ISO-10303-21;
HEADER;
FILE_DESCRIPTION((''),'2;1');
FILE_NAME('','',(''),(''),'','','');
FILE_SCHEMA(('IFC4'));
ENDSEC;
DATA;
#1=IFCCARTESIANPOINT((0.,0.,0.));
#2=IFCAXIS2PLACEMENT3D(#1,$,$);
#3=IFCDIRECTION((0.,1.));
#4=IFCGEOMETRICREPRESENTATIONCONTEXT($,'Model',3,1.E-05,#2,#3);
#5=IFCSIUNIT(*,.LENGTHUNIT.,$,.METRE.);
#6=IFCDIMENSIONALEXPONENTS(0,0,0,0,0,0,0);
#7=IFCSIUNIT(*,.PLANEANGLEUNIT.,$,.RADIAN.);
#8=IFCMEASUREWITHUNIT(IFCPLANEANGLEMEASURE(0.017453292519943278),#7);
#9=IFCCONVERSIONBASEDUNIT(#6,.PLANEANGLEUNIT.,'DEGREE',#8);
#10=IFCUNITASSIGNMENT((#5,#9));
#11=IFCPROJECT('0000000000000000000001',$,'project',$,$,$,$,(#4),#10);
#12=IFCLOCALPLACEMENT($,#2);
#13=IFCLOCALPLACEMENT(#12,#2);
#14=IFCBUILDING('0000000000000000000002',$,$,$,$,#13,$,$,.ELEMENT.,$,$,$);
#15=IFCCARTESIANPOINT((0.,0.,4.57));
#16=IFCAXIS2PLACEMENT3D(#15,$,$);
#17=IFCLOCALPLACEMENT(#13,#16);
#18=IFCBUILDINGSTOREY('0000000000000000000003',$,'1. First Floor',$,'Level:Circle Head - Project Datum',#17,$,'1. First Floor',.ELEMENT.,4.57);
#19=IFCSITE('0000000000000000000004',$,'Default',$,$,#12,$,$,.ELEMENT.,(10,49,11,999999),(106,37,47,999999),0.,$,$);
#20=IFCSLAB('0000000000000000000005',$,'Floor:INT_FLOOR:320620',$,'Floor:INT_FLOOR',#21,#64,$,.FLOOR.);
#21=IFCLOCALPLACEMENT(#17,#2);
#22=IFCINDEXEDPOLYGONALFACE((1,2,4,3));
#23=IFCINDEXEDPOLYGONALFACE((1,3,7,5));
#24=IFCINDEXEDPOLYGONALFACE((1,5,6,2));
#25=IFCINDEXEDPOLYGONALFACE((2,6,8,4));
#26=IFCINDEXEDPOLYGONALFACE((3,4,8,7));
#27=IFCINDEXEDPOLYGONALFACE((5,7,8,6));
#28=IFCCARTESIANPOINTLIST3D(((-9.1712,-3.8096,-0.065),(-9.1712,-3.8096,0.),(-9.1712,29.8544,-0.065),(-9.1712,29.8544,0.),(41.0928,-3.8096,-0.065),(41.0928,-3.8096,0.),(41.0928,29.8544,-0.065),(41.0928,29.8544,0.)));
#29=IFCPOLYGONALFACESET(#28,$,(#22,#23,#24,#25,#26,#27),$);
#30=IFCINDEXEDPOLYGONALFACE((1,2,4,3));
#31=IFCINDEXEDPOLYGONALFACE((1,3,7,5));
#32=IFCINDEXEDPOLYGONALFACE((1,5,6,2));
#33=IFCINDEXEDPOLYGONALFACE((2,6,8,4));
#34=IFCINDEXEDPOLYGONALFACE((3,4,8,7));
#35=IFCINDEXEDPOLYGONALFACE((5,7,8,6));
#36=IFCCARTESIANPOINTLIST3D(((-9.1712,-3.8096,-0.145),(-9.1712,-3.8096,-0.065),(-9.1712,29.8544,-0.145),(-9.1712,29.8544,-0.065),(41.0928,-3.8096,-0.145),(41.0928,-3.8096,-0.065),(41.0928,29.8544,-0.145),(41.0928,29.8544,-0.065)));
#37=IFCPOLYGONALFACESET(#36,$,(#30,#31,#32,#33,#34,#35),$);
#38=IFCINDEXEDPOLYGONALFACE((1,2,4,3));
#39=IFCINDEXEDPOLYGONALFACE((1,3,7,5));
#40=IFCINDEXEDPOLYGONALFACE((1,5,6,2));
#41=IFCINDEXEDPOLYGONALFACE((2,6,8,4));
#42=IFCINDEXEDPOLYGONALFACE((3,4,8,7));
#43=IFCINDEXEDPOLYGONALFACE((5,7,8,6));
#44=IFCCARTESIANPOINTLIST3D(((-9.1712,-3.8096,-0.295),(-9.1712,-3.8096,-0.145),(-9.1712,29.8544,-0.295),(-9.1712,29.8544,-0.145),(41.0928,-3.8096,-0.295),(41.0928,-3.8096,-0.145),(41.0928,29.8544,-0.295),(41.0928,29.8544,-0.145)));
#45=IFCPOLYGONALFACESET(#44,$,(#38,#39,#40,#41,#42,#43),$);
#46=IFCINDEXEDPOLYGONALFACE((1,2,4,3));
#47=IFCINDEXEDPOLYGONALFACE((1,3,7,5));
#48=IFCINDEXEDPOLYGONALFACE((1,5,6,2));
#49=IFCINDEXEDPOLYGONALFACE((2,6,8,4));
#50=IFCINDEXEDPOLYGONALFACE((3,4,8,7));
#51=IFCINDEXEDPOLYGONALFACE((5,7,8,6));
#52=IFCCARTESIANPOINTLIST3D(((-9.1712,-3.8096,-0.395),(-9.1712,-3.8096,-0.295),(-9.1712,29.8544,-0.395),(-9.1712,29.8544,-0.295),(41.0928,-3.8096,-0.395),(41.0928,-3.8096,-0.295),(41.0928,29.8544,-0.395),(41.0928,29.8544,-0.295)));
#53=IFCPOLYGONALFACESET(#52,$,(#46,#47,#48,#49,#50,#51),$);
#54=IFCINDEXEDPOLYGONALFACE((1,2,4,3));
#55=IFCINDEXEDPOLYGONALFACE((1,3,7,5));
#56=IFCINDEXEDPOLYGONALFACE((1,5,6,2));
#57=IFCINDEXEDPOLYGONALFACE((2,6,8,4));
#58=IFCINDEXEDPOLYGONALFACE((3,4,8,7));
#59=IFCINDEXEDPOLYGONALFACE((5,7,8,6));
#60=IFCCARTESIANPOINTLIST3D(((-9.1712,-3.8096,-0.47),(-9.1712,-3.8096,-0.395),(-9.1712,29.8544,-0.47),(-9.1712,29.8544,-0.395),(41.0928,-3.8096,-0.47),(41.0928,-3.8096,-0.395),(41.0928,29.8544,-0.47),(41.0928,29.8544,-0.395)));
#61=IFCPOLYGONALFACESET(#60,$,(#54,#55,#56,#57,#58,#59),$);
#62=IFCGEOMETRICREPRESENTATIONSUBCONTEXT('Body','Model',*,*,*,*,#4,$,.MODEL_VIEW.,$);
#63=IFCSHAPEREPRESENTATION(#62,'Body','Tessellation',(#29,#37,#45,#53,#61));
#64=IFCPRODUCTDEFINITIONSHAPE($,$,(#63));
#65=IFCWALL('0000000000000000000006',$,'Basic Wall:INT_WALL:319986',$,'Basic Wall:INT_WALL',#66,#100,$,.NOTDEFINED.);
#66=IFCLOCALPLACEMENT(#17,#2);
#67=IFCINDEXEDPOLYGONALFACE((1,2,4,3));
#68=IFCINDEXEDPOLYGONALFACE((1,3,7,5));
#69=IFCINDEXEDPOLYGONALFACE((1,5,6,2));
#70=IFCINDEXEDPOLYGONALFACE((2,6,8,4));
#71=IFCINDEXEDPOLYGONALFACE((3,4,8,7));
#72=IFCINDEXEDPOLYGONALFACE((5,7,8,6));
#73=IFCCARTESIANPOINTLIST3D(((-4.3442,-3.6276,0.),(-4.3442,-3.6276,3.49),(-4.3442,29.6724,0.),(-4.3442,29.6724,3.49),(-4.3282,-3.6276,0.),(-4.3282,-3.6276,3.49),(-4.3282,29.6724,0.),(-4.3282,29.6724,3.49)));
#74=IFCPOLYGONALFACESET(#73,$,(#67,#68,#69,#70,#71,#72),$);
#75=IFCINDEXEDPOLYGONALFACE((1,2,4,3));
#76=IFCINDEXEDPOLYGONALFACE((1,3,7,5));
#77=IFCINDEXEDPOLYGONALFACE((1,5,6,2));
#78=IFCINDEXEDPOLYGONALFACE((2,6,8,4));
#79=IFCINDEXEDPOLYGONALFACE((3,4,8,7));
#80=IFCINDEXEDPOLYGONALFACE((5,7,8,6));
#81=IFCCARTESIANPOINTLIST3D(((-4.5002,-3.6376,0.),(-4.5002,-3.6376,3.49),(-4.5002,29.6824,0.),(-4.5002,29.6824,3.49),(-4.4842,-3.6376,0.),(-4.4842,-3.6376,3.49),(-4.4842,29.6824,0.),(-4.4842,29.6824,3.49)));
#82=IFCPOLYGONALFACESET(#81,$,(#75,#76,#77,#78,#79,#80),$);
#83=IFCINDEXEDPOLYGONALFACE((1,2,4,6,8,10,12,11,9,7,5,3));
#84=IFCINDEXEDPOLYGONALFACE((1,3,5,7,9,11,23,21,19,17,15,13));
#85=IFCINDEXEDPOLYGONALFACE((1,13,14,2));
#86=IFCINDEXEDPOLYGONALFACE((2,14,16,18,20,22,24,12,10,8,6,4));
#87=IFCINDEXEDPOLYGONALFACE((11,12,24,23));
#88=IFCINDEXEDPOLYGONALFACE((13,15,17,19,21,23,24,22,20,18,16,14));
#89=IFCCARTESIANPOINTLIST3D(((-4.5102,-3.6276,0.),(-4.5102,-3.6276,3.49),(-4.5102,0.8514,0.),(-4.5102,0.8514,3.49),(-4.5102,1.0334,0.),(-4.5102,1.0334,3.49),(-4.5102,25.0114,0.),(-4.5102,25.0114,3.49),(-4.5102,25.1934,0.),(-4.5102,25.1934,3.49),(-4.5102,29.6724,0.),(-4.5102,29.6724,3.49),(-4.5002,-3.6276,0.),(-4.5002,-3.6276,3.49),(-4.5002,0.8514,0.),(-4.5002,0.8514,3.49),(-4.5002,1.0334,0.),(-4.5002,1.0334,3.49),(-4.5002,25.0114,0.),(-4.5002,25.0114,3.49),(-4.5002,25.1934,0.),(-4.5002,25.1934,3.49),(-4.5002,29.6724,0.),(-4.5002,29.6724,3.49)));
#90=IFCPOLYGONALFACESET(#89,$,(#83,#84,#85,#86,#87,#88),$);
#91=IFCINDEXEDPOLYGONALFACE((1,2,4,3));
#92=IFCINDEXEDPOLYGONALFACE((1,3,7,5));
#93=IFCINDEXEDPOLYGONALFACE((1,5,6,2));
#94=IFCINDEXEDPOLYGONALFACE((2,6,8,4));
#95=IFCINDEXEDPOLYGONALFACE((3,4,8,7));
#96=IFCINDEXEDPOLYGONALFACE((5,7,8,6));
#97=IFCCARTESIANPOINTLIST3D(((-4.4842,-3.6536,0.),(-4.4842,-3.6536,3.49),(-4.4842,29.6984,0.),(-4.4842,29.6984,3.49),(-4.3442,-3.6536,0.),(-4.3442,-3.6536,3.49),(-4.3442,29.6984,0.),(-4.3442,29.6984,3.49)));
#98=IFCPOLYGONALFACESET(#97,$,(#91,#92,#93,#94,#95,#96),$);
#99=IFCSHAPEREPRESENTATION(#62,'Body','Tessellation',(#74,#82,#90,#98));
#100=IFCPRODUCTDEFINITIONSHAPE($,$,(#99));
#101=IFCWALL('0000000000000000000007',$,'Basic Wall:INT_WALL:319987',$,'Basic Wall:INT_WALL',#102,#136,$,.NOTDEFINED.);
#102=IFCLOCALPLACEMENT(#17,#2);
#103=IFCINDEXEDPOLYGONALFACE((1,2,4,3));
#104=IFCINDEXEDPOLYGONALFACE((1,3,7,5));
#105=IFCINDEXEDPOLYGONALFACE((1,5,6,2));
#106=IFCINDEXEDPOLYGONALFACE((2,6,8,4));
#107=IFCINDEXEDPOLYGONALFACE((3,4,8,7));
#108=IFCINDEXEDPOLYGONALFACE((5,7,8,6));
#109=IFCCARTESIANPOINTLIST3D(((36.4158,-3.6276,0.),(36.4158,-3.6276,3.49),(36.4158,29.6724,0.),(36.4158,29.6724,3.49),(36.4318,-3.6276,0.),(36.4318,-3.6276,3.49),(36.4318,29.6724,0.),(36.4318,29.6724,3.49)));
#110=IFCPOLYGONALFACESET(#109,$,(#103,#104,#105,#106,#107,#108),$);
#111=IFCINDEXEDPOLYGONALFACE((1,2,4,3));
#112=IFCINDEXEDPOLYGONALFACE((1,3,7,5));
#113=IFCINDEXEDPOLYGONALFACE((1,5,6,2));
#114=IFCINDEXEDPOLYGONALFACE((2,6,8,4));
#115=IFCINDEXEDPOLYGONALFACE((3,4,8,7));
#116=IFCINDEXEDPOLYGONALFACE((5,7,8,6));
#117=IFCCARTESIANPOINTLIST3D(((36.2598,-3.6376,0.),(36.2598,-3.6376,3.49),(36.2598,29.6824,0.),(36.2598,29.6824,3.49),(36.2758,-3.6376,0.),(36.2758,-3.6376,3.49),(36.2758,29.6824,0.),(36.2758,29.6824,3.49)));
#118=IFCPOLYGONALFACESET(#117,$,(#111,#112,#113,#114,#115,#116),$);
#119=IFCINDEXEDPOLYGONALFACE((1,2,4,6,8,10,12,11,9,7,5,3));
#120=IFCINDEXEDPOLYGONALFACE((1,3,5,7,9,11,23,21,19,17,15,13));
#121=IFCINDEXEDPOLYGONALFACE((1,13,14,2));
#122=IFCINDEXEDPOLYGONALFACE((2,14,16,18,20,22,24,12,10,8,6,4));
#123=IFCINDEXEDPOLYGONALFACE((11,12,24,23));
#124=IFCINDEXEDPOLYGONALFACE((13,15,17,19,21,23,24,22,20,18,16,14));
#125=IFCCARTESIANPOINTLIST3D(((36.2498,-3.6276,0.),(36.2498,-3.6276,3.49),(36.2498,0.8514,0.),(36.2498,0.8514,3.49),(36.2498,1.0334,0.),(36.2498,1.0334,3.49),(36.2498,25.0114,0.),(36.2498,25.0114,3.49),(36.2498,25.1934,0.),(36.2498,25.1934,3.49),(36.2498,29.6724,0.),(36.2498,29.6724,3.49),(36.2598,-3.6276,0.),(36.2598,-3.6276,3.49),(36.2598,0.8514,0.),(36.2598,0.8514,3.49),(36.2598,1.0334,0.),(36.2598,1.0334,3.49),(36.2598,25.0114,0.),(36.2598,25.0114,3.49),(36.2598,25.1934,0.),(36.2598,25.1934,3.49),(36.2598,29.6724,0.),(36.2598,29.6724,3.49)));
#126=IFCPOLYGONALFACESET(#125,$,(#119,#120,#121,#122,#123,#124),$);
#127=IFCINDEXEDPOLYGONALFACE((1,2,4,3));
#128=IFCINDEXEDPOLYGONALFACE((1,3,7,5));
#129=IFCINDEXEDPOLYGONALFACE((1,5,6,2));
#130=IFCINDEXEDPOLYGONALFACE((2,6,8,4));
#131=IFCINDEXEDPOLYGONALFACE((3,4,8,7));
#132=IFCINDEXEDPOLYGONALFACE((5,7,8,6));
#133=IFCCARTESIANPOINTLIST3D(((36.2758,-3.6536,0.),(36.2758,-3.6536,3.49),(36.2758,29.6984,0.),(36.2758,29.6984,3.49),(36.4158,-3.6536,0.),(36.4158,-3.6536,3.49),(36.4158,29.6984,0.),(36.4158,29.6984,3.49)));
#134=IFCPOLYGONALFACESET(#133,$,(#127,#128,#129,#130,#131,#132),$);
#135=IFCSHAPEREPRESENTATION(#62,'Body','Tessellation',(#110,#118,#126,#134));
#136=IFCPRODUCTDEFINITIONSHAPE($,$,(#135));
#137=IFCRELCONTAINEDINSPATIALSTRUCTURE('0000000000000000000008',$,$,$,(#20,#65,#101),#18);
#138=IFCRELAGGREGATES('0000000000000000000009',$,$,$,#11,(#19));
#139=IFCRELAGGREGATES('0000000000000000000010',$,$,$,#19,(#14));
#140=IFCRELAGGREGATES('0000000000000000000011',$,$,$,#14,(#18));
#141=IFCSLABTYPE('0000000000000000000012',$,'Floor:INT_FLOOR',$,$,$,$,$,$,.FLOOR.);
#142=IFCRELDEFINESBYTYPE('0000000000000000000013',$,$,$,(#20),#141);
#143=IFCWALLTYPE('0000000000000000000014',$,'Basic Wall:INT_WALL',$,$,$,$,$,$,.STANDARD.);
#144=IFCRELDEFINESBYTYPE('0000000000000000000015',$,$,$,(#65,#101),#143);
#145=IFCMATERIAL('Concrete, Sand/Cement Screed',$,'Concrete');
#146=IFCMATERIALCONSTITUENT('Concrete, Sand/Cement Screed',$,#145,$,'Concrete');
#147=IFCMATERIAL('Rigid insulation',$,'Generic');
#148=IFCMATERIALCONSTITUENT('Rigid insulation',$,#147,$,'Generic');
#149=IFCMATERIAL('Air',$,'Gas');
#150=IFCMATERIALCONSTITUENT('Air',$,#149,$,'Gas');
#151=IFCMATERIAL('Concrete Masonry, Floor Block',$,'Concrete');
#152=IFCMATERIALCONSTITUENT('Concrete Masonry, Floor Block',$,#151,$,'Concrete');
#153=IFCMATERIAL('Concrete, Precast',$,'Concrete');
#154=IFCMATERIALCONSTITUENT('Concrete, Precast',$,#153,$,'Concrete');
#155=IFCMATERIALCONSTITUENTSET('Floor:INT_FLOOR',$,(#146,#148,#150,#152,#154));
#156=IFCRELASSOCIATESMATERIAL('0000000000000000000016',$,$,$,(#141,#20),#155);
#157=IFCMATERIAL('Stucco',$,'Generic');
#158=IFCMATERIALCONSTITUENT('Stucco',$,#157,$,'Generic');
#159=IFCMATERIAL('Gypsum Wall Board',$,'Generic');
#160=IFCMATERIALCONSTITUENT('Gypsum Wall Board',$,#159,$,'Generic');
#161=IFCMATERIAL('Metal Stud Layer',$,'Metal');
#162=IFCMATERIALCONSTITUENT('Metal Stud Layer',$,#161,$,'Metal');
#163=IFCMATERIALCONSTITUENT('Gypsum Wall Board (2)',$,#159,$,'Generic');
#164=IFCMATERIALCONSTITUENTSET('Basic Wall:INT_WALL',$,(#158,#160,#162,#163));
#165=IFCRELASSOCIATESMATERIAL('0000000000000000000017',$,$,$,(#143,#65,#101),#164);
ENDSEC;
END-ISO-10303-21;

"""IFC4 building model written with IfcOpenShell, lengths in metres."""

from ifc_helpers import new_model, entity, si_unit, converted_unit, direction, frame, origin, place, context, subcontext, project, spatial, indexed_curve, outline, extrude, material, constituent, constituent_set, type_object, element, save


model = new_model("IFC4")

# Units and contexts
model_context = context("Model", 3, precision=1e-05, world=origin(), true_north=direction((0.0, 1.0)))
body_context = subcontext(model_context, "Body", "Model", "MODEL_VIEW")
ifc_project = project(units=[si_unit("LENGTHUNIT", "METRE"), converted_unit("PLANEANGLEUNIT", "DEGREE", entity("IfcPlaneAngleMeasure", 0.017453292519943278), si_unit("PLANEANGLEUNIT", "RADIAN"), dimensions=[0, 0, 0, 0, 0, 0, 0])], contexts=[model_context])

# Site, building, storey
site_placement = place(None, origin())
site = spatial("IfcSite", under=ifc_project, at=site_placement, Name="Default", CompositionType="ELEMENT", RefLatitude=(10, 49, 11, 999999), RefLongitude=(106, 37, 47, 999999), RefElevation=0.0)
building_placement = place(site_placement, origin())
building = spatial("IfcBuilding", under=site, at=building_placement, CompositionType="ELEMENT")
storey_placement = place(building_placement, frame((0.0, 0.0, 4.57)))
storey = spatial("IfcBuildingStorey", under=building, at=storey_placement, Name="1. First Floor", ObjectType="Level:Circle Head - Project Datum", LongName="1. First Floor", CompositionType="ELEMENT", Elevation=4.57)

# Slab
ifc_material_1 = material(Name="Concrete, Sand/Cement Screed", Category="Concrete")
ifc_constituent_1 = constituent(ifc_material_1, Name="Concrete, Sand/Cement Screed", Category="Concrete")
ifc_material_2 = material(Name="Rigid insulation", Category="Generic")
ifc_constituent_2 = constituent(ifc_material_2, Name="Rigid insulation", Category="Generic")
ifc_material_3 = material(Name="Air", Category="Gas")
ifc_constituent_3 = constituent(ifc_material_3, Name="Air", Category="Gas")
ifc_material_4 = material(Name="Concrete Masonry, Floor Block", Category="Concrete")
ifc_constituent_4 = constituent(ifc_material_4, Name="Concrete Masonry, Floor Block", Category="Concrete")
ifc_material_5 = material(Name="Concrete, Precast", Category="Concrete")
ifc_constituent_5 = constituent(ifc_material_5, Name="Concrete, Precast", Category="Concrete")
ifc_constituent_set_1 = constituent_set(constituents=[ifc_constituent_1, ifc_constituent_2, ifc_constituent_3, ifc_constituent_4, ifc_constituent_5], Name="Floor:INT_FLOOR")
slab_type = type_object("IfcSlabType", Name="Floor:INT_FLOOR", PredefinedType="FLOOR", material=ifc_constituent_set_1)
slab_placement = place(storey_placement, origin())
element("IfcSlab", 1, at=slab_placement, inside=storey, type_object=slab_type, material=ifc_constituent_set_1, Name="Floor:INT_FLOOR:320620", ObjectType="Floor:INT_FLOOR", PredefinedType="FLOOR", context=body_context, shape_type="SweptSolid", body=[
    extrude(outline(indexed_curve([(-25.132, -16.832), (25.132, -16.832), (25.132, 16.832), (-25.132, 16.832), (-25.132, -16.832)], self_intersect=False)), frame((15.9608, 13.0224, -0.065), z_axis=(0.0, 0.0, 1.0), x_axis=(-1.0, 0.0, 0.0)), (0.0, 0.0, 1.0), 0.065),
    extrude(outline(indexed_curve([(-25.132, -16.832), (25.132, -16.832), (25.132, 16.832), (-25.132, 16.832), (-25.132, -16.832)], self_intersect=False)), frame((15.9608, 13.0224, -0.145), z_axis=(0.0, 0.0, 1.0), x_axis=(-1.0, 0.0, 0.0)), (0.0, 0.0, 1.0), 0.08),
    extrude(outline(indexed_curve([(-25.132, -16.832), (25.132, -16.832), (25.132, 16.832), (-25.132, 16.832), (-25.132, -16.832)], self_intersect=False)), frame((15.9608, 13.0224, -0.295), z_axis=(0.0, 0.0, 1.0), x_axis=(-1.0, 0.0, 0.0)), (0.0, 0.0, 1.0), 0.15),
    extrude(outline(indexed_curve([(-25.132, -16.832), (25.132, -16.832), (25.132, 16.832), (-25.132, 16.832), (-25.132, -16.832)], self_intersect=False)), frame((15.9608, 13.0224, -0.395), z_axis=(0.0, 0.0, 1.0), x_axis=(-1.0, 0.0, 0.0)), (0.0, 0.0, 1.0), 0.1),
    extrude(outline(indexed_curve([(-25.132, -16.832), (25.132, -16.832), (25.132, 16.832), (-25.132, 16.832), (-25.132, -16.832)], self_intersect=False)), frame((15.9608, 13.0224, -0.47), z_axis=(0.0, 0.0, 1.0), x_axis=(-1.0, 0.0, 0.0)), (0.0, 0.0, 1.0), 0.075),
])

# Walls
ifc_material_6 = material(Name="Stucco", Category="Generic")
ifc_constituent_6 = constituent(ifc_material_6, Name="Stucco", Category="Generic")
ifc_material_7 = material(Name="Gypsum Wall Board", Category="Generic")
ifc_constituent_7 = constituent(ifc_material_7, Name="Gypsum Wall Board", Category="Generic")
ifc_material_8 = material(Name="Metal Stud Layer", Category="Metal")
ifc_constituent_8 = constituent(ifc_material_8, Name="Metal Stud Layer", Category="Metal")
ifc_constituent_9 = constituent(ifc_material_7, Name="Gypsum Wall Board (2)", Category="Generic")
ifc_constituent_set_2 = constituent_set(constituents=[ifc_constituent_6, ifc_constituent_7, ifc_constituent_8, ifc_constituent_9], Name="Basic Wall:INT_WALL")
wall_type_1 = type_object("IfcWallType", Name="Basic Wall:INT_WALL", PredefinedType="STANDARD", material=ifc_constituent_set_2)
wall_1_placement = place(storey_placement, frame((-4.4192, -3.6276, 0.0), z_axis=(0.0, 0.0, 1.0), x_axis=(0.0, 1.0, 0.0)))
element("IfcWall", 2, at=wall_1_placement, inside=storey, type_object=wall_type_1, material=ifc_constituent_set_2, Name="Basic Wall:INT_WALL:319986", ObjectType="Basic Wall:INT_WALL", PredefinedType="NOTDEFINED", context=body_context, shape_type="SweptSolid", body=[
    extrude(outline(indexed_curve([(-1.745, -16.65), (1.745, -16.65), (1.745, 16.65), (-1.745, 16.65), (-1.745, -16.65)], self_intersect=False)), frame((16.65, -0.075, 1.745), z_axis=(0.0, -1.0, 0.0), x_axis=(0.0, 0.0, 1.0)), (0.0, 0.0, 1.0), 0.016),
    extrude(outline(indexed_curve([(-1.745, -16.66), (1.745, -16.66), (1.745, 16.66), (-1.745, 16.66), (-1.745, -16.66)], self_intersect=False)), frame((16.65, 0.081, 1.745), z_axis=(0.0, -1.0, 0.0), x_axis=(0.0, 0.0, 1.0)), (0.0, 0.0, 1.0), 0.016),
    extrude(outline(indexed_curve([(-16.65, -1.745), (-12.171, -1.745), (-11.989, -1.745), (11.989, -1.745), (12.171, -1.745), (16.65, -1.745), (16.65, 1.745), (12.171, 1.745), (11.989, 1.745), (-11.989, 1.745), (-12.171, 1.745), (-16.65, 1.745), (-16.65, -1.745)], self_intersect=False)), frame((16.65, 0.091, 1.745), z_axis=(0.0, -1.0, 0.0), x_axis=(1.0, 0.0, 0.0)), (0.0, 0.0, 1.0), 0.01),
    extrude(outline(indexed_curve([(-1.745, -16.676), (1.745, -16.676), (1.745, 16.676), (-1.745, 16.676), (-1.745, -16.676)], self_intersect=False)), frame((16.65, 0.065, 1.745), z_axis=(0.0, -1.0, 0.0), x_axis=(0.0, 0.0, 1.0)), (0.0, 0.0, 1.0), 0.14),
])
wall_2_placement = place(storey_placement, frame((36.3408, -3.6276, 0.0), z_axis=(0.0, 0.0, 1.0), x_axis=(0.0, 1.0, 0.0)))
element("IfcWall", 3, at=wall_2_placement, inside=storey, type_object=wall_type_1, material=ifc_constituent_set_2, Name="Basic Wall:INT_WALL:319987", ObjectType="Basic Wall:INT_WALL", PredefinedType="NOTDEFINED", context=body_context, shape_type="SweptSolid", body=[
    extrude(outline(indexed_curve([(-1.745, -16.65), (1.745, -16.65), (1.745, 16.65), (-1.745, 16.65), (-1.745, -16.65)], self_intersect=False)), frame((16.65, -0.075, 1.745), z_axis=(0.0, -1.0, 0.0), x_axis=(0.0, 0.0, 1.0)), (0.0, 0.0, 1.0), 0.016),
    extrude(outline(indexed_curve([(-1.745, -16.66), (1.745, -16.66), (1.745, 16.66), (-1.745, 16.66), (-1.745, -16.66)], self_intersect=False)), frame((16.65, 0.081, 1.745), z_axis=(0.0, -1.0, 0.0), x_axis=(0.0, 0.0, 1.0)), (0.0, 0.0, 1.0), 0.016),
    extrude(outline(indexed_curve([(-16.65, -1.745), (-12.171, -1.745), (-11.989, -1.745), (11.989, -1.745), (12.171, -1.745), (16.65, -1.745), (16.65, 1.745), (12.171, 1.745), (11.989, 1.745), (-11.989, 1.745), (-12.171, 1.745), (-16.65, 1.745), (-16.65, -1.745)], self_intersect=False)), frame((16.65, 0.091, 1.745), z_axis=(0.0, -1.0, 0.0), x_axis=(1.0, 0.0, 0.0)), (0.0, 0.0, 1.0), 0.01),
    extrude(outline(indexed_curve([(-1.745, -16.676), (1.745, -16.676), (1.745, 16.676), (-1.745, 16.676), (-1.745, -16.676)], self_intersect=False)), frame((16.65, 0.065, 1.745), z_axis=(0.0, -1.0, 0.0), x_axis=(0.0, 0.0, 1.0)), (0.0, 0.0, 1.0), 0.14),
])

save(model, "model.ifc")
